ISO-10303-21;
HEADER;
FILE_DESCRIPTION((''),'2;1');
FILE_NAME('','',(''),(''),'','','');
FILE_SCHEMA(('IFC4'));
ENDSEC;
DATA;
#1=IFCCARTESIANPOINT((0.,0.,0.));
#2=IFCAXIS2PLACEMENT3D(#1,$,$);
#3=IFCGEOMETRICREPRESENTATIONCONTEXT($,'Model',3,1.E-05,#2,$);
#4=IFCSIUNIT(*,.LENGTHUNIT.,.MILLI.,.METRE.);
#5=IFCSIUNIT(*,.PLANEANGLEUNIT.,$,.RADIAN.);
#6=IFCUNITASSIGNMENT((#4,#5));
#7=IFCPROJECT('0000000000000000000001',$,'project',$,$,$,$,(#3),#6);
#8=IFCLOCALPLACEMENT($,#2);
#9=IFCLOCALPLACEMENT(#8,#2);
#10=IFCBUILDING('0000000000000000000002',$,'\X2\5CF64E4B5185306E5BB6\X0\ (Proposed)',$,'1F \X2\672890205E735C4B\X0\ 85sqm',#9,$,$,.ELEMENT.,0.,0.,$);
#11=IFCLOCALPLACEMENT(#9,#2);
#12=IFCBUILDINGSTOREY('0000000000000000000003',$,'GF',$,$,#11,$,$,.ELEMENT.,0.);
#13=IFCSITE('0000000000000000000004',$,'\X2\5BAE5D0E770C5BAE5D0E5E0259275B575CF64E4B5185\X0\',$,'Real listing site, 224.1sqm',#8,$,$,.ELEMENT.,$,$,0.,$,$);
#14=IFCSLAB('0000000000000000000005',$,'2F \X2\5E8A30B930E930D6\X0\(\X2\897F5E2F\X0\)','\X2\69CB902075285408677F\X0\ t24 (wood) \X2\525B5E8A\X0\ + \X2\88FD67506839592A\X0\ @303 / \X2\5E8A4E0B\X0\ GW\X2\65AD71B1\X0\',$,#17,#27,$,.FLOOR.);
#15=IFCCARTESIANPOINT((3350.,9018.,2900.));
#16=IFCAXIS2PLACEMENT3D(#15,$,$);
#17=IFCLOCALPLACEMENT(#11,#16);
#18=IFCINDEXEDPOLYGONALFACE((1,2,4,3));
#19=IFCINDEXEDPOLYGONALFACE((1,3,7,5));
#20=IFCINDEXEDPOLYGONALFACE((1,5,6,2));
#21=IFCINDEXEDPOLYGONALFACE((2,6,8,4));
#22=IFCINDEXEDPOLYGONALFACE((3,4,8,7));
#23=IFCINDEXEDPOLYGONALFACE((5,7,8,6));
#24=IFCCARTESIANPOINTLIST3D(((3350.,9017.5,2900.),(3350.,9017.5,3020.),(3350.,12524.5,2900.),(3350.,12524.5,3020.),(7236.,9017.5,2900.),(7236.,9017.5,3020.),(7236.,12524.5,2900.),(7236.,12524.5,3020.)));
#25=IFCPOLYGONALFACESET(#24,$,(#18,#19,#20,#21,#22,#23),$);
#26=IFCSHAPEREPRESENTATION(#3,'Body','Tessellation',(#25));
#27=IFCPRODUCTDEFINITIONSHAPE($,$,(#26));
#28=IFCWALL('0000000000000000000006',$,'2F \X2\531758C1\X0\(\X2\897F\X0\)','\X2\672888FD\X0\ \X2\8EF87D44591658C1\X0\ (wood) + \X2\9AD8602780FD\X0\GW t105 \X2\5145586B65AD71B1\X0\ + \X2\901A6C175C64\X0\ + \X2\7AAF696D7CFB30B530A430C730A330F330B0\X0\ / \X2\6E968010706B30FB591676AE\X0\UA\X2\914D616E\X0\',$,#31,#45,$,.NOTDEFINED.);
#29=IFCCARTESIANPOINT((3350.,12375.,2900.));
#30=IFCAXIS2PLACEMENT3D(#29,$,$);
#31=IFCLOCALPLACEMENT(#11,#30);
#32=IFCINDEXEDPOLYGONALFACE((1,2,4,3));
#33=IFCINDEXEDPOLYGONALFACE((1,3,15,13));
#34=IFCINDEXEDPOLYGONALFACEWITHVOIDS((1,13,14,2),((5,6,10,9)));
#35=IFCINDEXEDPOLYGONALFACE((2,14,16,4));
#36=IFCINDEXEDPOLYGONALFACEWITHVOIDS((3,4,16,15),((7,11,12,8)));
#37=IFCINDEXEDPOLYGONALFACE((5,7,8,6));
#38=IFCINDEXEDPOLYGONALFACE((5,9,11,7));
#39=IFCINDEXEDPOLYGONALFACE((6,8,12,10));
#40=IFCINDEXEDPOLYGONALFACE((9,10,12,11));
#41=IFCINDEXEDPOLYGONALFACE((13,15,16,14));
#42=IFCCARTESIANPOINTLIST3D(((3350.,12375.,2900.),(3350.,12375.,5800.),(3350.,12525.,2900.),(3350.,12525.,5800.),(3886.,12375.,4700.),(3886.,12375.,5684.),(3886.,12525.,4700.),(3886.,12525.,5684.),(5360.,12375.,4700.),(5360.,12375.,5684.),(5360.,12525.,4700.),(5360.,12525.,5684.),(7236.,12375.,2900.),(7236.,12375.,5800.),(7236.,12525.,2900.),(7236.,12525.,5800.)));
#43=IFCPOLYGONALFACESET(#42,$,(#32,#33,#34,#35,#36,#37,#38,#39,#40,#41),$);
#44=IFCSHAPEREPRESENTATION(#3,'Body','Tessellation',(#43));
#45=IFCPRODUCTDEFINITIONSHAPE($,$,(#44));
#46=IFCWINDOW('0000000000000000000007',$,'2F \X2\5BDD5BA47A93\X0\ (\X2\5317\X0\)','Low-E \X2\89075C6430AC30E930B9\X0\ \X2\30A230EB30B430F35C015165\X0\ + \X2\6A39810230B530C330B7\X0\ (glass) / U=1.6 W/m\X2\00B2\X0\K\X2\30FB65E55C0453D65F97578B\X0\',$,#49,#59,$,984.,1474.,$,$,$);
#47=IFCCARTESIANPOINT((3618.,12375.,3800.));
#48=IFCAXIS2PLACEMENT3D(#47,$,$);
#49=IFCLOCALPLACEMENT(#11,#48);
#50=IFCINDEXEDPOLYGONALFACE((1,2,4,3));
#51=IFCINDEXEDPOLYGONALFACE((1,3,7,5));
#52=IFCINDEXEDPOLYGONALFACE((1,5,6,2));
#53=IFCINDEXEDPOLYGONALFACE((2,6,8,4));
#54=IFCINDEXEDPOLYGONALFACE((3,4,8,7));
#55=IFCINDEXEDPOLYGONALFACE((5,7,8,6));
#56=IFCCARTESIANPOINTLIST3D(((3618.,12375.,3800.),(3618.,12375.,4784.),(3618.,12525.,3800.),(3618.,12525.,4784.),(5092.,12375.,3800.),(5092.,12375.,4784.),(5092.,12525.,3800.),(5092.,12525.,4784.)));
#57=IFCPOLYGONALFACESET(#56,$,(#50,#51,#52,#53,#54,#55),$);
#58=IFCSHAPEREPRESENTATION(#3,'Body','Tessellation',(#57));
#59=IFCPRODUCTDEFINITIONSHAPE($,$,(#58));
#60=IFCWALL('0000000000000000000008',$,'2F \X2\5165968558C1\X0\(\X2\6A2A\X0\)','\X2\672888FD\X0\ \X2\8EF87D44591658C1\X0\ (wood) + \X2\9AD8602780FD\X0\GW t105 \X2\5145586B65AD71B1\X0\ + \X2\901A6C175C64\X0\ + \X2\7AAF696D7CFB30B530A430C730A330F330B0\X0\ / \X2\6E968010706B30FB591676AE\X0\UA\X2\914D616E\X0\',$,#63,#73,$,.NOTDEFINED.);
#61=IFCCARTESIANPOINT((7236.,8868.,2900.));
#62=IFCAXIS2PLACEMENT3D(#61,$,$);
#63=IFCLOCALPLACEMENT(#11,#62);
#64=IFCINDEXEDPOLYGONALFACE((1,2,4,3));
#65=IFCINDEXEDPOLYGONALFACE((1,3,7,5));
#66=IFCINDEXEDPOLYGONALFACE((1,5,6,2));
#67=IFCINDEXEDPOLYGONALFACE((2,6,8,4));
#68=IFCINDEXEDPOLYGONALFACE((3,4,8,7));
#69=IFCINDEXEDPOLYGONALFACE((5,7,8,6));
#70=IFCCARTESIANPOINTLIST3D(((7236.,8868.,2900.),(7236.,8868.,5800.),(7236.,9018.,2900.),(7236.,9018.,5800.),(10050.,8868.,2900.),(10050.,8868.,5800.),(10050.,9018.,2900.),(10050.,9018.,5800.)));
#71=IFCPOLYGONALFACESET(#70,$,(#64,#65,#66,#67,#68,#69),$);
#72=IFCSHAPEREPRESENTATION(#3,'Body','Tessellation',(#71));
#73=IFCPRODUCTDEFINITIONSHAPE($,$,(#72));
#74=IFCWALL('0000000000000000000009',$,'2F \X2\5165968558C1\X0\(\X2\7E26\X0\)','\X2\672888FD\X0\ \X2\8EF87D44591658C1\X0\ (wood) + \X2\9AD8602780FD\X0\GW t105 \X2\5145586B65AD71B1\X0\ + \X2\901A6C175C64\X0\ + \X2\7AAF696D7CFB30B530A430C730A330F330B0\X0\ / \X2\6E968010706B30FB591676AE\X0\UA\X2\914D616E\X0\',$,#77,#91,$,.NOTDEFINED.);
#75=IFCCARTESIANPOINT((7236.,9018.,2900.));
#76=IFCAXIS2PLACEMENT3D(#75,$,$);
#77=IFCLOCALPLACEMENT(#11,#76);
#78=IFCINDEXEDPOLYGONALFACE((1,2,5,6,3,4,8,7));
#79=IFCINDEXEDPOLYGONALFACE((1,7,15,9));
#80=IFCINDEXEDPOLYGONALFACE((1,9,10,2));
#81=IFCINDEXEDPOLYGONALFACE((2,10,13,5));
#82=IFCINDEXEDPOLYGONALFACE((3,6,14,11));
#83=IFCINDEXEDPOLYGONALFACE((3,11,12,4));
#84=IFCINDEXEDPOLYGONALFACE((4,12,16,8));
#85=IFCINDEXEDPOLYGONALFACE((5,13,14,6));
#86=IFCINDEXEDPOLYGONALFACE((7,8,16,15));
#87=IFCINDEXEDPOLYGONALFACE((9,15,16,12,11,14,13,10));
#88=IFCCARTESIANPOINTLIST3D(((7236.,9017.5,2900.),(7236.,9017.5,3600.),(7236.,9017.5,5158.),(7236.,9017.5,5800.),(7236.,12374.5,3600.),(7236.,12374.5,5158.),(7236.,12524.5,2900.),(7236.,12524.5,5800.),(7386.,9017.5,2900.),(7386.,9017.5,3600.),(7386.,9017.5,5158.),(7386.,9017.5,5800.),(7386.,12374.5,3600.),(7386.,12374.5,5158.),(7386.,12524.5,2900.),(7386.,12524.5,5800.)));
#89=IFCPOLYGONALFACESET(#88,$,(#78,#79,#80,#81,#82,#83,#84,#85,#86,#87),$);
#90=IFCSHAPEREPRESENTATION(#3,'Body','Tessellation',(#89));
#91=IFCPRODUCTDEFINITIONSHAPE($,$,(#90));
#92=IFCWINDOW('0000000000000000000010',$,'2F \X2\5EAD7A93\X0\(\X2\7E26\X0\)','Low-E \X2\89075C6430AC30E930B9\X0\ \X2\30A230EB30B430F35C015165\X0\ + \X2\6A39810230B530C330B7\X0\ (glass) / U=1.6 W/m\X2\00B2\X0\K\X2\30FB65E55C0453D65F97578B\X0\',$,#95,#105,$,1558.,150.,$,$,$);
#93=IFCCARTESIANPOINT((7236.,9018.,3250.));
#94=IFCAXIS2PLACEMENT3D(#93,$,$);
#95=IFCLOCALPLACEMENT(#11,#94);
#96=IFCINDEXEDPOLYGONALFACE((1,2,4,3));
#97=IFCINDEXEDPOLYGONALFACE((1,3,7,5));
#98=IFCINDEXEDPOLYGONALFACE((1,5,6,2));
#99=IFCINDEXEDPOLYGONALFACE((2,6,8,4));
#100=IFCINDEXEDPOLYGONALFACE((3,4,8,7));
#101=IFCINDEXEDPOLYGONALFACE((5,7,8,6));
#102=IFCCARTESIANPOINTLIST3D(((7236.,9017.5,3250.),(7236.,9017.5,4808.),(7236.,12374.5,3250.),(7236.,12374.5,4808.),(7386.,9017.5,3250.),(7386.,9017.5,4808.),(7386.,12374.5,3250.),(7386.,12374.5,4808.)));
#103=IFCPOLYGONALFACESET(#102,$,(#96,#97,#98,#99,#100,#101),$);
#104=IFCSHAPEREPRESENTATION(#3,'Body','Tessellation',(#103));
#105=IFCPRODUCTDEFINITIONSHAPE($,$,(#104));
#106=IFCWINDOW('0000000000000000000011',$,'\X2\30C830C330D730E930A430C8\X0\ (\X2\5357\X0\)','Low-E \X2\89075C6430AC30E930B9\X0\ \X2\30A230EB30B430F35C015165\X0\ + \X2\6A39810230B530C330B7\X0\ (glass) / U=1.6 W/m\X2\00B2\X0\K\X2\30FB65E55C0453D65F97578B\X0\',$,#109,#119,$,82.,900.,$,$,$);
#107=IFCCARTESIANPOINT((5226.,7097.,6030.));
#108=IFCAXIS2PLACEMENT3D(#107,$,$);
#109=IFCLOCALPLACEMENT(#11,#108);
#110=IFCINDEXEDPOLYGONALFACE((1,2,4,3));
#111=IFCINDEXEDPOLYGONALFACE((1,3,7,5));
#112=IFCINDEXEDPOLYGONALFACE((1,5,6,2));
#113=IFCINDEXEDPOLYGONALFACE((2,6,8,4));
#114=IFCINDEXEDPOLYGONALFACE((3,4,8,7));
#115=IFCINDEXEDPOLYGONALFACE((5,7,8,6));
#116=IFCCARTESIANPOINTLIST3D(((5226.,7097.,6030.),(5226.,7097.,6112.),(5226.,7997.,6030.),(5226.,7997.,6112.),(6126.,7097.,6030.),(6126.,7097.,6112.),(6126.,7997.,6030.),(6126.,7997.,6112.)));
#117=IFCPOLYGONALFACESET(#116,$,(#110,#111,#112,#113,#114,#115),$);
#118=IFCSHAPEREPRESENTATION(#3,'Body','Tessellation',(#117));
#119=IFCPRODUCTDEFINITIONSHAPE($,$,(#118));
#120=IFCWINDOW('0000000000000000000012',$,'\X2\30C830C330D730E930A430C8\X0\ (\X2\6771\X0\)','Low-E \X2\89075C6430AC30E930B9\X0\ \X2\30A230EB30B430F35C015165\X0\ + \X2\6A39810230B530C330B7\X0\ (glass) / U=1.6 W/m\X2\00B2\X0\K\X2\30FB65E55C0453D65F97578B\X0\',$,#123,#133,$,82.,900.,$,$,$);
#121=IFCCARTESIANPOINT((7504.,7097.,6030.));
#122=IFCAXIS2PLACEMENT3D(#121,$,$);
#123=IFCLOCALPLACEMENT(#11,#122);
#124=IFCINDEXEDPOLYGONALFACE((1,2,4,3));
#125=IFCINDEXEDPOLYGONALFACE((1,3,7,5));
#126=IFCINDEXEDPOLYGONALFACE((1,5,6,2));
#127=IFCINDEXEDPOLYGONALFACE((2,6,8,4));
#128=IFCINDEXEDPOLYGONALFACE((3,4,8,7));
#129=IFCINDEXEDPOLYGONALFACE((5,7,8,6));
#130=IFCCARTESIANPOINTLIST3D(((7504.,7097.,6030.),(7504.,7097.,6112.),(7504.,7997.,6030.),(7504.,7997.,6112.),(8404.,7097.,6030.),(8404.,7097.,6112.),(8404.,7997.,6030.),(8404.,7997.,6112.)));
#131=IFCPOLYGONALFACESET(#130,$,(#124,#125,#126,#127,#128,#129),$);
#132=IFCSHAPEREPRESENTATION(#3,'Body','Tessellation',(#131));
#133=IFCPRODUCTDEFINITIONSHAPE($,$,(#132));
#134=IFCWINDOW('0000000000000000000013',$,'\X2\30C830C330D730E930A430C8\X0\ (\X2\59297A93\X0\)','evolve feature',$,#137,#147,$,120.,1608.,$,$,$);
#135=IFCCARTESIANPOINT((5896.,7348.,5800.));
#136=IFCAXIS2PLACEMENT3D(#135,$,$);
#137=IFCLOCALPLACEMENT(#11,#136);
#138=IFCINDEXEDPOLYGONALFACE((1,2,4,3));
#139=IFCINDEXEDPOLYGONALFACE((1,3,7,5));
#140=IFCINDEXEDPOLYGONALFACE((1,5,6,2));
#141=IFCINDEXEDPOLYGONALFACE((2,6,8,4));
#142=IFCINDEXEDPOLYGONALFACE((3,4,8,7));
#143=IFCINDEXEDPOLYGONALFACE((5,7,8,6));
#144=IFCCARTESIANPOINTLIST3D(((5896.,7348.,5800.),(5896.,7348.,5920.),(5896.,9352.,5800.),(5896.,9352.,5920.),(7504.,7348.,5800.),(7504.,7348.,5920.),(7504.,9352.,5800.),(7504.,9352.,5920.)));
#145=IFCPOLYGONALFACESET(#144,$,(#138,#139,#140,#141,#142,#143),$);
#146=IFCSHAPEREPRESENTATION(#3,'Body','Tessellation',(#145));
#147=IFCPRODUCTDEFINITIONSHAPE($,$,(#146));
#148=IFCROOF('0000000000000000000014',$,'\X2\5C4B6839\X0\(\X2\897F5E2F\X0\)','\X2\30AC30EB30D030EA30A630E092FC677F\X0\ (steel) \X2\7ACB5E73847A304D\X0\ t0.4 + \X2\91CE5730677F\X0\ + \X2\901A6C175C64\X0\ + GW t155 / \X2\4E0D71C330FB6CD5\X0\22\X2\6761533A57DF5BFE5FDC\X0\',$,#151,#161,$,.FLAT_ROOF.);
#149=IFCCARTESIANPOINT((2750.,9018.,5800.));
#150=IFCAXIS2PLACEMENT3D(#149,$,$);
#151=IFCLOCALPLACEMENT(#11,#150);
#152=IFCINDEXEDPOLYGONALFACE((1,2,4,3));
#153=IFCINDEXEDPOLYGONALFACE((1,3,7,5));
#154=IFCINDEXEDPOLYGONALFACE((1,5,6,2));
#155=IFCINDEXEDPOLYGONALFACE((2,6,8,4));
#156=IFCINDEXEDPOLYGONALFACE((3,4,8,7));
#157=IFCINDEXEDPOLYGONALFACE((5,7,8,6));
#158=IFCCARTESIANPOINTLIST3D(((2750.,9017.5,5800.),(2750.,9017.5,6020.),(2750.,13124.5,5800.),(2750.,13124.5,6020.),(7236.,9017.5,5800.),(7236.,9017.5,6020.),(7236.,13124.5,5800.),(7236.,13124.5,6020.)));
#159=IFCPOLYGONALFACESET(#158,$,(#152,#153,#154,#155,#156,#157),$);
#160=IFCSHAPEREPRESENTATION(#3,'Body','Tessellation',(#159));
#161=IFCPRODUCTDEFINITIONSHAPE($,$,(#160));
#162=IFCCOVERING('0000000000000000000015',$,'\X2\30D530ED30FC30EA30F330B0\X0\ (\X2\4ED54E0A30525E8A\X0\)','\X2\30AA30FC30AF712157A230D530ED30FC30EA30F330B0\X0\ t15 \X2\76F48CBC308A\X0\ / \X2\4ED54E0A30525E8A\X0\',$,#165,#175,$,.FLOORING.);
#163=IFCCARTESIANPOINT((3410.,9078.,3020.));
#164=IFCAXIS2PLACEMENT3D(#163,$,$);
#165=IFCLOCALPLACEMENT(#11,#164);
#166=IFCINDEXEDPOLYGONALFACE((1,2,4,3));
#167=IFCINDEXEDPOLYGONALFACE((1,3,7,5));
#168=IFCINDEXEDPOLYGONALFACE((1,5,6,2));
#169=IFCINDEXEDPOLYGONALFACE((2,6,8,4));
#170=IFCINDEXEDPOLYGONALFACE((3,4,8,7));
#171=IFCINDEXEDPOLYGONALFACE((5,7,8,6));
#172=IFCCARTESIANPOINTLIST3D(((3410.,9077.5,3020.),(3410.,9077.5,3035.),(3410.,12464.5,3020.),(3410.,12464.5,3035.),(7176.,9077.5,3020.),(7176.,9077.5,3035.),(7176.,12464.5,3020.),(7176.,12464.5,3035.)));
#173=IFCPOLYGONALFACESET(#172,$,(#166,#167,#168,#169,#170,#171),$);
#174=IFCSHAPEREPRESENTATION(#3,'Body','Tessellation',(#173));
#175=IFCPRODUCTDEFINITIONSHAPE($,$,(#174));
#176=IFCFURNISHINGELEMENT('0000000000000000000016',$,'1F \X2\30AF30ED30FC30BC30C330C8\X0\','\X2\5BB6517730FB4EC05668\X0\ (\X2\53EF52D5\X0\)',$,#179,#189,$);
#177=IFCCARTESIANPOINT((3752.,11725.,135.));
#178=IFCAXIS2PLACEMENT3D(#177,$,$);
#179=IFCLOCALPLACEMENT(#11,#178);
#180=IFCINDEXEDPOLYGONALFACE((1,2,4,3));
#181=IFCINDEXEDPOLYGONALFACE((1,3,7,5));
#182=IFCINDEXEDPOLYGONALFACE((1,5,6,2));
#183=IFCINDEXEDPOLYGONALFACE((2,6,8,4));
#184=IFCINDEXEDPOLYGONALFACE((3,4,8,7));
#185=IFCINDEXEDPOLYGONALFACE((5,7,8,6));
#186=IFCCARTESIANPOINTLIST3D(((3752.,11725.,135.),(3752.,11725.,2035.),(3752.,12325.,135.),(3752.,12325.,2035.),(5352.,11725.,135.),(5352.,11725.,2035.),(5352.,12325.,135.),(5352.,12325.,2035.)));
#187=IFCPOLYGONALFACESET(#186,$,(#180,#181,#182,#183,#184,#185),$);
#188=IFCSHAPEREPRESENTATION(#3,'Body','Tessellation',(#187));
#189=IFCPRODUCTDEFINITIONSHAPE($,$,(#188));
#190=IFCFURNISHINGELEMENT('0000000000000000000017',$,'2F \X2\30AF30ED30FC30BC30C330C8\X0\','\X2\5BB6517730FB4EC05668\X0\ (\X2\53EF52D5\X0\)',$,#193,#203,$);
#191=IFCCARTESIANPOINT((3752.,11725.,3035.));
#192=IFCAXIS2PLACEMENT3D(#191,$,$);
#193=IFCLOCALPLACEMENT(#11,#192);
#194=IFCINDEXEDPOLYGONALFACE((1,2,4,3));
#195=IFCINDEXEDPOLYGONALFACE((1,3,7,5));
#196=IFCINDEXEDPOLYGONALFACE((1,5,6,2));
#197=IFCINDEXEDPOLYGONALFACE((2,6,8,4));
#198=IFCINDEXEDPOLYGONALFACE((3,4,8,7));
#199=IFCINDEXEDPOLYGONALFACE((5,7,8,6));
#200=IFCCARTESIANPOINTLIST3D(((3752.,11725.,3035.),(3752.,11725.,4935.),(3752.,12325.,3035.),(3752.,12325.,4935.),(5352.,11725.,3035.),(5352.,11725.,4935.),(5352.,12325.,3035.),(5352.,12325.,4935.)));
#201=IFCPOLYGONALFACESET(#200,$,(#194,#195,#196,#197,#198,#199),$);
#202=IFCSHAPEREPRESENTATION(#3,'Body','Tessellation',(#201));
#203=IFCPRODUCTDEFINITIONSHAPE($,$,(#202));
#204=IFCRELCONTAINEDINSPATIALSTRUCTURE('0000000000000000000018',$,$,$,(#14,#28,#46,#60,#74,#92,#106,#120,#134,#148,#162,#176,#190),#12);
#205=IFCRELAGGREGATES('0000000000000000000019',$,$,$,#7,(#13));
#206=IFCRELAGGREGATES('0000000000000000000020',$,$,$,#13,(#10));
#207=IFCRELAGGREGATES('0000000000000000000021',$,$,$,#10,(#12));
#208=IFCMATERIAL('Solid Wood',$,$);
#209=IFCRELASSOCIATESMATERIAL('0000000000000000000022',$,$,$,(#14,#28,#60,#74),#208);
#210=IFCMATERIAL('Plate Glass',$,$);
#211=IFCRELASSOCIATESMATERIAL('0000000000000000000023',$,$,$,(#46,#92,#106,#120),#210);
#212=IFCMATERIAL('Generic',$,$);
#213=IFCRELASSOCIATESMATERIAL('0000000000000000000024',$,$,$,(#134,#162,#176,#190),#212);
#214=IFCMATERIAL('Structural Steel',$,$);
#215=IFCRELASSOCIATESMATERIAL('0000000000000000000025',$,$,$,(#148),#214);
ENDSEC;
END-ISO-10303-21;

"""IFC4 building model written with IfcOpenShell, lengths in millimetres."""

from ifc_helpers import new_model, si_unit, frame, frame_2d, origin, place, context, project, spatial, rectangle, extrude, material, element, fill, save


model = new_model("IFC4")

# Units and contexts
model_context = context("Model", 3, precision=1e-05, world=origin())
ifc_project = project(units=[si_unit("LENGTHUNIT", "METRE", prefix="MILLI"), si_unit("PLANEANGLEUNIT", "RADIAN")], contexts=[model_context])

# Site, building, storey
site_placement = place(None, origin())
site = spatial("IfcSite", under=ifc_project, at=site_placement, Name="宮崎県宮崎市大字島之内", ObjectType="Real listing site, 224.1sqm", CompositionType="ELEMENT", RefElevation=0.0)
building_placement = place(site_placement, origin())
building = spatial("IfcBuilding", under=site, at=building_placement, Name="島之内の家 (Proposed)", ObjectType="1F 木造平屋 85sqm", CompositionType="ELEMENT", ElevationOfRefHeight=0.0, ElevationOfTerrain=0.0)
storey_placement = place(building_placement, origin())
storey = spatial("IfcBuildingStorey", under=building, at=storey_placement, Name="GF", CompositionType="ELEMENT", Elevation=0.0)

# Slab
ifc_material_1 = material(Name="Solid Wood")
slab_placement = place(storey_placement, frame((3350.0, 9018.0, 2900.0)))
element("IfcSlab", 1, at=slab_placement, inside=storey, material=ifc_material_1, Name="2F 床スラブ(西帯)", Description="構造用合板 t24 (wood) 剛床 + 製材根太 @303 / 床下 GW断熱", PredefinedType="FLOOR", context=model_context, shape_type="SweptSolid", body=[
    extrude(rectangle(XDim=3886.0, YDim=3507.0, at=frame_2d((1943.0, 1753.0))), frame((3350.0, 9018.0, 2900.0)), (0.0, 0.0, 1.0), 120.0),
])

# Wall, opening, window
wall_1_placement = place(storey_placement, frame((3350.0, 12375.0, 2900.0)))
wall_1 = element("IfcWall", 2, at=wall_1_placement, inside=storey, material=ifc_material_1, Name="2F 北壁(西)", Description="木製 軸組外壁 (wood) + 高性能GW t105 充填断熱 + 通気層 + 窯業系サイディング / 準耐火・外皮UA配慮", PredefinedType="NOTDEFINED", context=model_context, shape_type="SweptSolid", body=[
    extrude(rectangle(XDim=3886.0, YDim=150.0, at=frame_2d((1943.0, 75.0))), frame((3350.0, 12375.0, 2900.0)), (0.0, 0.0, 1.0), 2900.0),
])
opening_1_placement = place(storey_placement, frame((3618.0, 12375.0, 3800.0)))
opening_1 = element("IfcOpeningElement", 3, at=opening_1_placement, cuts=wall_1, PredefinedType="NOTDEFINED", context=model_context, shape_type="SweptSolid", body=[
    extrude(rectangle(XDim=1474.0, YDim=150.0, at=frame_2d((737.0, 75.0))), frame((3618.0, 12375.0, 3800.0)), (0.0, 0.0, 1.0), 984.0),
])
ifc_material_2 = material(Name="Plate Glass")
window_1_placement = place(storey_placement, frame((3618.0, 12375.0, 3800.0)))
window_1 = element("IfcWindow", 4, at=window_1_placement, inside=storey, material=ifc_material_2, Name="2F 寝室窓 (北)", Description="Low-E 複層ガラス アルゴン封入 + 樹脂サッシ (glass) / U=1.6 W/m²K・日射取得型", OverallHeight=984.0, OverallWidth=1474.0, context=model_context, shape_type="SweptSolid", body=[
    extrude(rectangle(XDim=1474.0, YDim=150.0, at=frame_2d((737.0, 75.0))), frame((3618.0, 12375.0, 3800.0)), (0.0, 0.0, 1.0), 984.0),
])
fill(opening_1, window_1)

# Wall
wall_2_placement = place(storey_placement, frame((7236.0, 8868.0, 2900.0)))
element("IfcWall", 5, at=wall_2_placement, inside=storey, material=ifc_material_1, Name="2F 入隅壁(横)", Description="木製 軸組外壁 (wood) + 高性能GW t105 充填断熱 + 通気層 + 窯業系サイディング / 準耐火・外皮UA配慮", PredefinedType="NOTDEFINED", context=model_context, shape_type="SweptSolid", body=[
    extrude(rectangle(XDim=2814.0, YDim=150.0, at=frame_2d((1407.0, 75.0))), frame((7236.0, 8868.0, 2900.0)), (0.0, 0.0, 1.0), 2900.0),
])

# Wall, opening, window
wall_3_placement = place(storey_placement, frame((7236.0, 9018.0, 2900.0)))
wall_3 = element("IfcWall", 6, at=wall_3_placement, inside=storey, material=ifc_material_1, Name="2F 入隅壁(縦)", Description="木製 軸組外壁 (wood) + 高性能GW t105 充填断熱 + 通気層 + 窯業系サイディング / 準耐火・外皮UA配慮", PredefinedType="NOTDEFINED", context=model_context, shape_type="SweptSolid", body=[
    extrude(rectangle(XDim=150.0, YDim=3507.0, at=frame_2d((75.0, 1753.0))), frame((7236.0, 9018.0, 2900.0)), (0.0, 0.0, 1.0), 2900.0),
])
opening_2_placement = place(storey_placement, frame((7236.0, 9018.0, 3250.0)))
opening_2 = element("IfcOpeningElement", 7, at=opening_2_placement, cuts=wall_3, PredefinedType="NOTDEFINED", context=model_context, shape_type="SweptSolid", body=[
    extrude(rectangle(XDim=150.0, YDim=3357.0, at=frame_2d((75.0, 1678.0))), frame((7236.0, 9018.0, 3250.0)), (0.0, 0.0, 1.0), 1558.0),
])
window_2_placement = place(storey_placement, frame((7236.0, 9018.0, 3250.0)))
window_2 = element("IfcWindow", 8, at=window_2_placement, inside=storey, material=ifc_material_2, Name="2F 庭窓(縦)", Description="Low-E 複層ガラス アルゴン封入 + 樹脂サッシ (glass) / U=1.6 W/m²K・日射取得型", OverallHeight=1558.0, OverallWidth=150.0, context=model_context, shape_type="SweptSolid", body=[
    extrude(rectangle(XDim=150.0, YDim=3357.0, at=frame_2d((75.0, 1678.0))), frame((7236.0, 9018.0, 3250.0)), (0.0, 0.0, 1.0), 1558.0),
])
fill(opening_2, window_2)

# Windows
window_3_placement = place(storey_placement, frame((5226.0, 7097.0, 6030.0)))
element("IfcWindow", 9, at=window_3_placement, inside=storey, material=ifc_material_2, Name="トップライト (南)", Description="Low-E 複層ガラス アルゴン封入 + 樹脂サッシ (glass) / U=1.6 W/m²K・日射取得型", OverallHeight=82.0, OverallWidth=900.0, context=model_context, shape_type="SweptSolid", body=[
    extrude(rectangle(XDim=900.0, YDim=900.0, at=frame_2d((450.0, 450.0))), frame((5226.0, 7097.0, 6030.0)), (0.0, 0.0, 1.0), 82.0),
])
window_4_placement = place(storey_placement, frame((7504.0, 7097.0, 6030.0)))
element("IfcWindow", 10, at=window_4_placement, inside=storey, material=ifc_material_2, Name="トップライト (東)", Description="Low-E 複層ガラス アルゴン封入 + 樹脂サッシ (glass) / U=1.6 W/m²K・日射取得型", OverallHeight=82.0, OverallWidth=900.0, context=model_context, shape_type="SweptSolid", body=[
    extrude(rectangle(XDim=900.0, YDim=900.0, at=frame_2d((450.0, 450.0))), frame((7504.0, 7097.0, 6030.0)), (0.0, 0.0, 1.0), 82.0),
])
ifc_material_3 = material(Name="Generic")
window_5_placement = place(storey_placement, frame((5896.0, 7348.0, 5800.0)))
element("IfcWindow", 11, at=window_5_placement, inside=storey, material=ifc_material_3, Name="トップライト (天窓)", Description="evolve feature", OverallHeight=120.0, OverallWidth=1608.0, context=model_context, shape_type="SweptSolid", body=[
    extrude(rectangle(XDim=1608.0, YDim=2004.0, at=frame_2d((804.0, 1002.0))), frame((5896.0, 7348.0, 5800.0)), (0.0, 0.0, 1.0), 120.0),
])

# Roof
ifc_material_4 = material(Name="Structural Steel")
for number, where, name in (
    (12, (2750.0, 9018.0, 5800.0), "屋根(西帯)"),
):
    element("IfcRoof", number, at=place(storey_placement, frame(where)), inside=storey, material=ifc_material_4, Name=name, Description="ガルバリウム鋼板 (steel) 立平葺き t0.4 + 野地板 + 通気層 + GW t155 / 不燃・法22条区域対応", PredefinedType="FLAT_ROOF", context=model_context, shape_type="SweptSolid", body=[
        extrude(rectangle(XDim=4486.0, YDim=4107.0, at=frame_2d((2243.0, 2053.0))), frame((2750.0, 9018.0, 5800.0)), (0.0, 0.0, 1.0), 220.0),
    ])

# Covering
covering_placement = place(storey_placement, frame((3410.0, 9078.0, 3020.0)))
element("IfcCovering", 13, at=covering_placement, inside=storey, material=ifc_material_3, Name="フローリング (仕上げ床)", Description="オーク無垢フローリング t15 直貼り / 仕上げ床", PredefinedType="FLOORING", context=model_context, shape_type="SweptSolid", body=[
    extrude(rectangle(XDim=3766.0, YDim=3387.0, at=frame_2d((1883.0, 1693.0))), frame((3410.0, 9078.0, 3020.0)), (0.0, 0.0, 1.0), 15.0),
])

# Furnishing elements
furnishing_1_placement = place(storey_placement, frame((3752.0, 11725.0, 135.0)))
element("IfcFurnishingElement", 14, at=furnishing_1_placement, inside=storey, material=ifc_material_3, Name="1F クローゼット", Description="家具・什器 (可動)", context=model_context, shape_type="SweptSolid", body=[
    extrude(rectangle(XDim=1600.0, YDim=600.0, at=frame_2d((800.0, 300.0))), frame((3752.0, 11725.0, 135.0)), (0.0, 0.0, 1.0), 1900.0),
])
furnishing_2_placement = place(storey_placement, frame((3752.0, 11725.0, 3035.0)))
element("IfcFurnishingElement", 15, at=furnishing_2_placement, inside=storey, material=ifc_material_3, Name="2F クローゼット", Description="家具・什器 (可動)", context=model_context, shape_type="SweptSolid", body=[
    extrude(rectangle(XDim=1600.0, YDim=600.0, at=frame_2d((800.0, 300.0))), frame((3752.0, 11725.0, 3035.0)), (0.0, 0.0, 1.0), 1900.0),
])

save(model, "model.ifc")
